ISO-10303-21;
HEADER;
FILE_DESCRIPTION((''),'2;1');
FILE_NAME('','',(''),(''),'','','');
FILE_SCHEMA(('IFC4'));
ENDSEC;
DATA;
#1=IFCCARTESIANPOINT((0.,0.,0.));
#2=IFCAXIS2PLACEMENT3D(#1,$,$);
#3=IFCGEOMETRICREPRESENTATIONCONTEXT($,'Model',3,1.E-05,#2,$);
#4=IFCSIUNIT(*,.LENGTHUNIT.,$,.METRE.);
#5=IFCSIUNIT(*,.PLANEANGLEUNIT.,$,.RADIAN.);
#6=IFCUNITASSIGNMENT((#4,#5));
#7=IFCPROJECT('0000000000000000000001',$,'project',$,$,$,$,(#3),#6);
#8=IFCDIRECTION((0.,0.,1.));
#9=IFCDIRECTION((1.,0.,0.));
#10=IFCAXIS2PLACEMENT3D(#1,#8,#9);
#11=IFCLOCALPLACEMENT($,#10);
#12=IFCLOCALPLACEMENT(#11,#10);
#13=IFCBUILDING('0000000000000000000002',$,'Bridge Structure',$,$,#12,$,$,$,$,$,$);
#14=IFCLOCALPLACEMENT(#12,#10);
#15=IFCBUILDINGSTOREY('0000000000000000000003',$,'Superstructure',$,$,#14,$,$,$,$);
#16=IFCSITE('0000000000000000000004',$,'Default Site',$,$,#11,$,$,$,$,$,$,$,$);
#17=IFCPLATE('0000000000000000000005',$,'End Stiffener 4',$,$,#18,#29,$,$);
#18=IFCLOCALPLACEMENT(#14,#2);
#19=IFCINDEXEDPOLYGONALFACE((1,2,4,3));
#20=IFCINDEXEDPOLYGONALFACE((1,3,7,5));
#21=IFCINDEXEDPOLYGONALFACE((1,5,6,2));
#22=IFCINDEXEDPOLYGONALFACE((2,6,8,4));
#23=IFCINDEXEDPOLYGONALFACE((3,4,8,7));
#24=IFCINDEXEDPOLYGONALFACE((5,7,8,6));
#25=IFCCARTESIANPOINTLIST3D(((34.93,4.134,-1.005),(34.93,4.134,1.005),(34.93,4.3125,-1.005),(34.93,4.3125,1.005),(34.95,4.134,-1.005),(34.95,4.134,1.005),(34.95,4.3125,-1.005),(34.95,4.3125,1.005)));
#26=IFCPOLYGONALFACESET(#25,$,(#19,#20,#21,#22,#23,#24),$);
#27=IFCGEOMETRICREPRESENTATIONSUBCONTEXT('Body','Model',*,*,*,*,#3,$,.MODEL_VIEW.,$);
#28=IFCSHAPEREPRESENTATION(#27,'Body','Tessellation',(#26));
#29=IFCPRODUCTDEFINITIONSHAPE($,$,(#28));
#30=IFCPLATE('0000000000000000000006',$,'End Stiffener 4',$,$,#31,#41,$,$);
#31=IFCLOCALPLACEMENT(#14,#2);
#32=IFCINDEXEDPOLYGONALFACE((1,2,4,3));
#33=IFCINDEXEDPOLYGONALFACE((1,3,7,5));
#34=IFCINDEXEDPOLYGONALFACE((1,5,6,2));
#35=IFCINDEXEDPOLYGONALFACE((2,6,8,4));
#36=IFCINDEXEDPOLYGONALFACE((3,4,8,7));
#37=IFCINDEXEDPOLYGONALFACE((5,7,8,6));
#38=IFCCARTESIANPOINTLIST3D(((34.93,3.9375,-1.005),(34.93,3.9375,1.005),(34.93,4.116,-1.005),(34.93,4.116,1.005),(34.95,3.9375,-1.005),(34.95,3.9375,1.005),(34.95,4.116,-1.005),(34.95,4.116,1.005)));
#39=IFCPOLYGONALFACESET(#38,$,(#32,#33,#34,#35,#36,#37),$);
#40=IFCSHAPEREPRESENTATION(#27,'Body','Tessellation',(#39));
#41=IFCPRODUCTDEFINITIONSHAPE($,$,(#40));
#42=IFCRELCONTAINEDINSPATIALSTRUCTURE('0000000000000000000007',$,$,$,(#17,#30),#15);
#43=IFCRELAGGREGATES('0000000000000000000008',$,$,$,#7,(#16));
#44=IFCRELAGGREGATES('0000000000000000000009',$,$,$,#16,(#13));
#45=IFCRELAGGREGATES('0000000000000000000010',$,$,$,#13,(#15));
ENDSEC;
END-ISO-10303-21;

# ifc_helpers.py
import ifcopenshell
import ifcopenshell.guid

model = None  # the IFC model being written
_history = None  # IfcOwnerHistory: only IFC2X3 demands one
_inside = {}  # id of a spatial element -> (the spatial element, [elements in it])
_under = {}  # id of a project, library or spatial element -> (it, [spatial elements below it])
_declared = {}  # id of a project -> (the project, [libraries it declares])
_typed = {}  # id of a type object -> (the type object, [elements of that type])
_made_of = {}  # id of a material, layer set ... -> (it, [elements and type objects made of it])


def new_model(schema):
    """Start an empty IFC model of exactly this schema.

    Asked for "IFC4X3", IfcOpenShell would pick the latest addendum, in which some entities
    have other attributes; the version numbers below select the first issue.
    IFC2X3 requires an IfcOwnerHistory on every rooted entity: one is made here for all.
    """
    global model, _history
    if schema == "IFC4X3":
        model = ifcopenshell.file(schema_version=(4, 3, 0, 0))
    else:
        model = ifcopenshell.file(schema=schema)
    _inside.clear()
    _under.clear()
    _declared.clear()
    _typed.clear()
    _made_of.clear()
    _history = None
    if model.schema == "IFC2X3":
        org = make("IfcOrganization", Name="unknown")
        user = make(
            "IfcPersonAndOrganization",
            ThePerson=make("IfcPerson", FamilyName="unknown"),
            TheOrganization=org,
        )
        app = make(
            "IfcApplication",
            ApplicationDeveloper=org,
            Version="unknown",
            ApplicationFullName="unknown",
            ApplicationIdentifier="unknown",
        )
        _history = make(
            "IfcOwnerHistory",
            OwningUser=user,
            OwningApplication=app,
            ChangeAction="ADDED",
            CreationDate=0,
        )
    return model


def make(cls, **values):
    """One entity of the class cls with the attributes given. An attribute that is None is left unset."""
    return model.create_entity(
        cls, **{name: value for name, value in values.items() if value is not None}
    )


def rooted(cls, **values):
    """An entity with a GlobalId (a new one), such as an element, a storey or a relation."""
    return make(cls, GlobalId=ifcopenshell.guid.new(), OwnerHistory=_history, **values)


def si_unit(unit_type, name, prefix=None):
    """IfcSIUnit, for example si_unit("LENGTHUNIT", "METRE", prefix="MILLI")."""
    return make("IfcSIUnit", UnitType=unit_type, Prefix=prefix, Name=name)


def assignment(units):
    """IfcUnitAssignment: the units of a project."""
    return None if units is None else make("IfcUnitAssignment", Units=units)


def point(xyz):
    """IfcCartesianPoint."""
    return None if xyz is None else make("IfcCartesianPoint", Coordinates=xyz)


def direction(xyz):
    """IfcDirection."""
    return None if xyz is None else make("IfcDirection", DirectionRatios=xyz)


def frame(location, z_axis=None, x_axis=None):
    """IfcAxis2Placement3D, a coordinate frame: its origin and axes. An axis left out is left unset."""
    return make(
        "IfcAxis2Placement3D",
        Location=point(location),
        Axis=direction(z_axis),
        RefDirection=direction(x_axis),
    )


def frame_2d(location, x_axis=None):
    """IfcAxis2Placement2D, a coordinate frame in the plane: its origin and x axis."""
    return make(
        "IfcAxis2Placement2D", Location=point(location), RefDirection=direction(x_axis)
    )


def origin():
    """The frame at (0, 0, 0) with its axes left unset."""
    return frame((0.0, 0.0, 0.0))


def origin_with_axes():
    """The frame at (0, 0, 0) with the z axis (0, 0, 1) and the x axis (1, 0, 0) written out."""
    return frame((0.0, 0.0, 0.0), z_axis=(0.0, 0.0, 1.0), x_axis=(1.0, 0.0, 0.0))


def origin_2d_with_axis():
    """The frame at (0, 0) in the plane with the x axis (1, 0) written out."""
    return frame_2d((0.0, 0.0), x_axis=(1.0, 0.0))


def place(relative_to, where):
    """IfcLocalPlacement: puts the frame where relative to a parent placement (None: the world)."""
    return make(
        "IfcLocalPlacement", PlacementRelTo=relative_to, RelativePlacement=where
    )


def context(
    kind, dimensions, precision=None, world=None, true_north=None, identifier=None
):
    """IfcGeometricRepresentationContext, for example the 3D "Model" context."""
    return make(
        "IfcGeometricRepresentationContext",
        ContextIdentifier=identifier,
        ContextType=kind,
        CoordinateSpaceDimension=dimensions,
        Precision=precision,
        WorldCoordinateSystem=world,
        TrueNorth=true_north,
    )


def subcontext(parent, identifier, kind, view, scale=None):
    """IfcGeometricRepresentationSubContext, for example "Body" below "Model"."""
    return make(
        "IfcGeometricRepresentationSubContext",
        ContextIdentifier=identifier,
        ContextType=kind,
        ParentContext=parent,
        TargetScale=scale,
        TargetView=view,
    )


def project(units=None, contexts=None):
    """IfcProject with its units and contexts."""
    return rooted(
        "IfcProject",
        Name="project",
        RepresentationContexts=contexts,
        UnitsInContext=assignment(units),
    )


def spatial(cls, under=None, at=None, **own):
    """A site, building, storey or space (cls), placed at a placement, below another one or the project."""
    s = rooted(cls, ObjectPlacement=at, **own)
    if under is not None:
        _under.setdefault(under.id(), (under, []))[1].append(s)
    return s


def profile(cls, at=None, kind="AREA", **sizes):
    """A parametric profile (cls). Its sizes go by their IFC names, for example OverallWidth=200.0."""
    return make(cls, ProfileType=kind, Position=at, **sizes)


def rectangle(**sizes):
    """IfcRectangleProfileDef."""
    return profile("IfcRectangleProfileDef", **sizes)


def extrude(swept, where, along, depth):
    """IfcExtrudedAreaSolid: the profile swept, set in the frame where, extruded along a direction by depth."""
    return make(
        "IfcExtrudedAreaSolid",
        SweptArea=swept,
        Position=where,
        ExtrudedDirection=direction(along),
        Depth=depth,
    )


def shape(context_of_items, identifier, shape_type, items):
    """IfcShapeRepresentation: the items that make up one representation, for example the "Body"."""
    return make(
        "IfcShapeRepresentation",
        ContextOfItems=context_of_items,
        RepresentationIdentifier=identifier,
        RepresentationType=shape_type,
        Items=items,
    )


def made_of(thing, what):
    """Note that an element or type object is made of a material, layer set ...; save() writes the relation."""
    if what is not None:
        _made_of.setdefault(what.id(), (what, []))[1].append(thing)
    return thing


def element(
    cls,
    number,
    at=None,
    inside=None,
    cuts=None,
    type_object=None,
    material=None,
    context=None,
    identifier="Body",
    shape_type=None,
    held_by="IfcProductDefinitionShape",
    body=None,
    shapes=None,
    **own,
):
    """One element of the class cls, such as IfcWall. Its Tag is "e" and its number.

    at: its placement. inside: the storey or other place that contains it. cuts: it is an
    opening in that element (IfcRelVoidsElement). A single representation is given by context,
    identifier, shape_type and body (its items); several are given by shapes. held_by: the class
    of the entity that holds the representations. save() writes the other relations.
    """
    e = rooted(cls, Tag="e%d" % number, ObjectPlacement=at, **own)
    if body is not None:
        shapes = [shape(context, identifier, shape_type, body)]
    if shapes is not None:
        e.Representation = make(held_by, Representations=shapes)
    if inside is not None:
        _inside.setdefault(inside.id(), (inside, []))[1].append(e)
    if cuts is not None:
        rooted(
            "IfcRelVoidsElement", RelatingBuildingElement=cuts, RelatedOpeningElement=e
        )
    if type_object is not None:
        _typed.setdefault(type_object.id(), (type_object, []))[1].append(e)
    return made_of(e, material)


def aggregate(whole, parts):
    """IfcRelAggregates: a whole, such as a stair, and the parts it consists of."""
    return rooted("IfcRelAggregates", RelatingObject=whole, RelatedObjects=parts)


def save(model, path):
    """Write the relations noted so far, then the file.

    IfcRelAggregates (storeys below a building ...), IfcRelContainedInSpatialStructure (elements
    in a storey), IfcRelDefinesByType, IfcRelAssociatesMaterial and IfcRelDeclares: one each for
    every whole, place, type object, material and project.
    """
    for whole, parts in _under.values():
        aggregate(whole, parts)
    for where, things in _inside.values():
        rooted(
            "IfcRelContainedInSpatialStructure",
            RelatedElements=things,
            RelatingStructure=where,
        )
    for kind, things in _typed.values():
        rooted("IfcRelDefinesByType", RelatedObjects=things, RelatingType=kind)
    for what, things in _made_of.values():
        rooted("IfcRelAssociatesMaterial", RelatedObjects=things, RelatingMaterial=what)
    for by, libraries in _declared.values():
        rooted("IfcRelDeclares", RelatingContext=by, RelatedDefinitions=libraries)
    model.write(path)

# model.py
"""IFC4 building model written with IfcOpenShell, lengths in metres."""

from ifc_helpers import new_model, si_unit, frame, origin, origin_with_axes, origin_2d_with_axis, place, context, subcontext, project, spatial, rectangle, extrude, element, save


model = new_model("IFC4")

# Units and contexts
model_context = context("Model", 3, precision=1e-05, world=origin())
body_context = subcontext(model_context, "Body", "Model", "MODEL_VIEW")
ifc_project = project(units=[si_unit("LENGTHUNIT", "METRE"), si_unit("PLANEANGLEUNIT", "RADIAN")], contexts=[model_context])

# Site, building, storey
site_placement = place(None, origin_with_axes())
site = spatial("IfcSite", under=ifc_project, at=site_placement, Name="Default Site")
building_placement = place(site_placement, origin_with_axes())
building = spatial("IfcBuilding", under=site, at=building_placement, Name="Bridge Structure")
storey_placement = place(building_placement, origin_with_axes())
storey = spatial("IfcBuildingStorey", under=building, at=storey_placement, Name="Superstructure")

# Plates
for number, where, z_axis, x_axis, name in (
    (1, (34.94, 4.2233, -1.005), (0.0, 0.0, 1.0), (1.0, 0.0, 0.0), "End Stiffener 4"),
    (2, (34.94, 4.0267, -1.005), (0.0, 0.0, 1.0), (1.0, 0.0, 0.0), "End Stiffener 4"),
):
    element("IfcPlate", number, at=place(storey_placement, frame(where, z_axis=z_axis, x_axis=x_axis)), inside=storey, Name=name, context=body_context, shape_type="SweptSolid", body=[
        extrude(rectangle(XDim=0.02, YDim=0.1785, at=origin_2d_with_axis()), origin_with_axes(), (0.0, 0.0, 1.0), 2.01),
    ])

save(model, "model.ifc")
